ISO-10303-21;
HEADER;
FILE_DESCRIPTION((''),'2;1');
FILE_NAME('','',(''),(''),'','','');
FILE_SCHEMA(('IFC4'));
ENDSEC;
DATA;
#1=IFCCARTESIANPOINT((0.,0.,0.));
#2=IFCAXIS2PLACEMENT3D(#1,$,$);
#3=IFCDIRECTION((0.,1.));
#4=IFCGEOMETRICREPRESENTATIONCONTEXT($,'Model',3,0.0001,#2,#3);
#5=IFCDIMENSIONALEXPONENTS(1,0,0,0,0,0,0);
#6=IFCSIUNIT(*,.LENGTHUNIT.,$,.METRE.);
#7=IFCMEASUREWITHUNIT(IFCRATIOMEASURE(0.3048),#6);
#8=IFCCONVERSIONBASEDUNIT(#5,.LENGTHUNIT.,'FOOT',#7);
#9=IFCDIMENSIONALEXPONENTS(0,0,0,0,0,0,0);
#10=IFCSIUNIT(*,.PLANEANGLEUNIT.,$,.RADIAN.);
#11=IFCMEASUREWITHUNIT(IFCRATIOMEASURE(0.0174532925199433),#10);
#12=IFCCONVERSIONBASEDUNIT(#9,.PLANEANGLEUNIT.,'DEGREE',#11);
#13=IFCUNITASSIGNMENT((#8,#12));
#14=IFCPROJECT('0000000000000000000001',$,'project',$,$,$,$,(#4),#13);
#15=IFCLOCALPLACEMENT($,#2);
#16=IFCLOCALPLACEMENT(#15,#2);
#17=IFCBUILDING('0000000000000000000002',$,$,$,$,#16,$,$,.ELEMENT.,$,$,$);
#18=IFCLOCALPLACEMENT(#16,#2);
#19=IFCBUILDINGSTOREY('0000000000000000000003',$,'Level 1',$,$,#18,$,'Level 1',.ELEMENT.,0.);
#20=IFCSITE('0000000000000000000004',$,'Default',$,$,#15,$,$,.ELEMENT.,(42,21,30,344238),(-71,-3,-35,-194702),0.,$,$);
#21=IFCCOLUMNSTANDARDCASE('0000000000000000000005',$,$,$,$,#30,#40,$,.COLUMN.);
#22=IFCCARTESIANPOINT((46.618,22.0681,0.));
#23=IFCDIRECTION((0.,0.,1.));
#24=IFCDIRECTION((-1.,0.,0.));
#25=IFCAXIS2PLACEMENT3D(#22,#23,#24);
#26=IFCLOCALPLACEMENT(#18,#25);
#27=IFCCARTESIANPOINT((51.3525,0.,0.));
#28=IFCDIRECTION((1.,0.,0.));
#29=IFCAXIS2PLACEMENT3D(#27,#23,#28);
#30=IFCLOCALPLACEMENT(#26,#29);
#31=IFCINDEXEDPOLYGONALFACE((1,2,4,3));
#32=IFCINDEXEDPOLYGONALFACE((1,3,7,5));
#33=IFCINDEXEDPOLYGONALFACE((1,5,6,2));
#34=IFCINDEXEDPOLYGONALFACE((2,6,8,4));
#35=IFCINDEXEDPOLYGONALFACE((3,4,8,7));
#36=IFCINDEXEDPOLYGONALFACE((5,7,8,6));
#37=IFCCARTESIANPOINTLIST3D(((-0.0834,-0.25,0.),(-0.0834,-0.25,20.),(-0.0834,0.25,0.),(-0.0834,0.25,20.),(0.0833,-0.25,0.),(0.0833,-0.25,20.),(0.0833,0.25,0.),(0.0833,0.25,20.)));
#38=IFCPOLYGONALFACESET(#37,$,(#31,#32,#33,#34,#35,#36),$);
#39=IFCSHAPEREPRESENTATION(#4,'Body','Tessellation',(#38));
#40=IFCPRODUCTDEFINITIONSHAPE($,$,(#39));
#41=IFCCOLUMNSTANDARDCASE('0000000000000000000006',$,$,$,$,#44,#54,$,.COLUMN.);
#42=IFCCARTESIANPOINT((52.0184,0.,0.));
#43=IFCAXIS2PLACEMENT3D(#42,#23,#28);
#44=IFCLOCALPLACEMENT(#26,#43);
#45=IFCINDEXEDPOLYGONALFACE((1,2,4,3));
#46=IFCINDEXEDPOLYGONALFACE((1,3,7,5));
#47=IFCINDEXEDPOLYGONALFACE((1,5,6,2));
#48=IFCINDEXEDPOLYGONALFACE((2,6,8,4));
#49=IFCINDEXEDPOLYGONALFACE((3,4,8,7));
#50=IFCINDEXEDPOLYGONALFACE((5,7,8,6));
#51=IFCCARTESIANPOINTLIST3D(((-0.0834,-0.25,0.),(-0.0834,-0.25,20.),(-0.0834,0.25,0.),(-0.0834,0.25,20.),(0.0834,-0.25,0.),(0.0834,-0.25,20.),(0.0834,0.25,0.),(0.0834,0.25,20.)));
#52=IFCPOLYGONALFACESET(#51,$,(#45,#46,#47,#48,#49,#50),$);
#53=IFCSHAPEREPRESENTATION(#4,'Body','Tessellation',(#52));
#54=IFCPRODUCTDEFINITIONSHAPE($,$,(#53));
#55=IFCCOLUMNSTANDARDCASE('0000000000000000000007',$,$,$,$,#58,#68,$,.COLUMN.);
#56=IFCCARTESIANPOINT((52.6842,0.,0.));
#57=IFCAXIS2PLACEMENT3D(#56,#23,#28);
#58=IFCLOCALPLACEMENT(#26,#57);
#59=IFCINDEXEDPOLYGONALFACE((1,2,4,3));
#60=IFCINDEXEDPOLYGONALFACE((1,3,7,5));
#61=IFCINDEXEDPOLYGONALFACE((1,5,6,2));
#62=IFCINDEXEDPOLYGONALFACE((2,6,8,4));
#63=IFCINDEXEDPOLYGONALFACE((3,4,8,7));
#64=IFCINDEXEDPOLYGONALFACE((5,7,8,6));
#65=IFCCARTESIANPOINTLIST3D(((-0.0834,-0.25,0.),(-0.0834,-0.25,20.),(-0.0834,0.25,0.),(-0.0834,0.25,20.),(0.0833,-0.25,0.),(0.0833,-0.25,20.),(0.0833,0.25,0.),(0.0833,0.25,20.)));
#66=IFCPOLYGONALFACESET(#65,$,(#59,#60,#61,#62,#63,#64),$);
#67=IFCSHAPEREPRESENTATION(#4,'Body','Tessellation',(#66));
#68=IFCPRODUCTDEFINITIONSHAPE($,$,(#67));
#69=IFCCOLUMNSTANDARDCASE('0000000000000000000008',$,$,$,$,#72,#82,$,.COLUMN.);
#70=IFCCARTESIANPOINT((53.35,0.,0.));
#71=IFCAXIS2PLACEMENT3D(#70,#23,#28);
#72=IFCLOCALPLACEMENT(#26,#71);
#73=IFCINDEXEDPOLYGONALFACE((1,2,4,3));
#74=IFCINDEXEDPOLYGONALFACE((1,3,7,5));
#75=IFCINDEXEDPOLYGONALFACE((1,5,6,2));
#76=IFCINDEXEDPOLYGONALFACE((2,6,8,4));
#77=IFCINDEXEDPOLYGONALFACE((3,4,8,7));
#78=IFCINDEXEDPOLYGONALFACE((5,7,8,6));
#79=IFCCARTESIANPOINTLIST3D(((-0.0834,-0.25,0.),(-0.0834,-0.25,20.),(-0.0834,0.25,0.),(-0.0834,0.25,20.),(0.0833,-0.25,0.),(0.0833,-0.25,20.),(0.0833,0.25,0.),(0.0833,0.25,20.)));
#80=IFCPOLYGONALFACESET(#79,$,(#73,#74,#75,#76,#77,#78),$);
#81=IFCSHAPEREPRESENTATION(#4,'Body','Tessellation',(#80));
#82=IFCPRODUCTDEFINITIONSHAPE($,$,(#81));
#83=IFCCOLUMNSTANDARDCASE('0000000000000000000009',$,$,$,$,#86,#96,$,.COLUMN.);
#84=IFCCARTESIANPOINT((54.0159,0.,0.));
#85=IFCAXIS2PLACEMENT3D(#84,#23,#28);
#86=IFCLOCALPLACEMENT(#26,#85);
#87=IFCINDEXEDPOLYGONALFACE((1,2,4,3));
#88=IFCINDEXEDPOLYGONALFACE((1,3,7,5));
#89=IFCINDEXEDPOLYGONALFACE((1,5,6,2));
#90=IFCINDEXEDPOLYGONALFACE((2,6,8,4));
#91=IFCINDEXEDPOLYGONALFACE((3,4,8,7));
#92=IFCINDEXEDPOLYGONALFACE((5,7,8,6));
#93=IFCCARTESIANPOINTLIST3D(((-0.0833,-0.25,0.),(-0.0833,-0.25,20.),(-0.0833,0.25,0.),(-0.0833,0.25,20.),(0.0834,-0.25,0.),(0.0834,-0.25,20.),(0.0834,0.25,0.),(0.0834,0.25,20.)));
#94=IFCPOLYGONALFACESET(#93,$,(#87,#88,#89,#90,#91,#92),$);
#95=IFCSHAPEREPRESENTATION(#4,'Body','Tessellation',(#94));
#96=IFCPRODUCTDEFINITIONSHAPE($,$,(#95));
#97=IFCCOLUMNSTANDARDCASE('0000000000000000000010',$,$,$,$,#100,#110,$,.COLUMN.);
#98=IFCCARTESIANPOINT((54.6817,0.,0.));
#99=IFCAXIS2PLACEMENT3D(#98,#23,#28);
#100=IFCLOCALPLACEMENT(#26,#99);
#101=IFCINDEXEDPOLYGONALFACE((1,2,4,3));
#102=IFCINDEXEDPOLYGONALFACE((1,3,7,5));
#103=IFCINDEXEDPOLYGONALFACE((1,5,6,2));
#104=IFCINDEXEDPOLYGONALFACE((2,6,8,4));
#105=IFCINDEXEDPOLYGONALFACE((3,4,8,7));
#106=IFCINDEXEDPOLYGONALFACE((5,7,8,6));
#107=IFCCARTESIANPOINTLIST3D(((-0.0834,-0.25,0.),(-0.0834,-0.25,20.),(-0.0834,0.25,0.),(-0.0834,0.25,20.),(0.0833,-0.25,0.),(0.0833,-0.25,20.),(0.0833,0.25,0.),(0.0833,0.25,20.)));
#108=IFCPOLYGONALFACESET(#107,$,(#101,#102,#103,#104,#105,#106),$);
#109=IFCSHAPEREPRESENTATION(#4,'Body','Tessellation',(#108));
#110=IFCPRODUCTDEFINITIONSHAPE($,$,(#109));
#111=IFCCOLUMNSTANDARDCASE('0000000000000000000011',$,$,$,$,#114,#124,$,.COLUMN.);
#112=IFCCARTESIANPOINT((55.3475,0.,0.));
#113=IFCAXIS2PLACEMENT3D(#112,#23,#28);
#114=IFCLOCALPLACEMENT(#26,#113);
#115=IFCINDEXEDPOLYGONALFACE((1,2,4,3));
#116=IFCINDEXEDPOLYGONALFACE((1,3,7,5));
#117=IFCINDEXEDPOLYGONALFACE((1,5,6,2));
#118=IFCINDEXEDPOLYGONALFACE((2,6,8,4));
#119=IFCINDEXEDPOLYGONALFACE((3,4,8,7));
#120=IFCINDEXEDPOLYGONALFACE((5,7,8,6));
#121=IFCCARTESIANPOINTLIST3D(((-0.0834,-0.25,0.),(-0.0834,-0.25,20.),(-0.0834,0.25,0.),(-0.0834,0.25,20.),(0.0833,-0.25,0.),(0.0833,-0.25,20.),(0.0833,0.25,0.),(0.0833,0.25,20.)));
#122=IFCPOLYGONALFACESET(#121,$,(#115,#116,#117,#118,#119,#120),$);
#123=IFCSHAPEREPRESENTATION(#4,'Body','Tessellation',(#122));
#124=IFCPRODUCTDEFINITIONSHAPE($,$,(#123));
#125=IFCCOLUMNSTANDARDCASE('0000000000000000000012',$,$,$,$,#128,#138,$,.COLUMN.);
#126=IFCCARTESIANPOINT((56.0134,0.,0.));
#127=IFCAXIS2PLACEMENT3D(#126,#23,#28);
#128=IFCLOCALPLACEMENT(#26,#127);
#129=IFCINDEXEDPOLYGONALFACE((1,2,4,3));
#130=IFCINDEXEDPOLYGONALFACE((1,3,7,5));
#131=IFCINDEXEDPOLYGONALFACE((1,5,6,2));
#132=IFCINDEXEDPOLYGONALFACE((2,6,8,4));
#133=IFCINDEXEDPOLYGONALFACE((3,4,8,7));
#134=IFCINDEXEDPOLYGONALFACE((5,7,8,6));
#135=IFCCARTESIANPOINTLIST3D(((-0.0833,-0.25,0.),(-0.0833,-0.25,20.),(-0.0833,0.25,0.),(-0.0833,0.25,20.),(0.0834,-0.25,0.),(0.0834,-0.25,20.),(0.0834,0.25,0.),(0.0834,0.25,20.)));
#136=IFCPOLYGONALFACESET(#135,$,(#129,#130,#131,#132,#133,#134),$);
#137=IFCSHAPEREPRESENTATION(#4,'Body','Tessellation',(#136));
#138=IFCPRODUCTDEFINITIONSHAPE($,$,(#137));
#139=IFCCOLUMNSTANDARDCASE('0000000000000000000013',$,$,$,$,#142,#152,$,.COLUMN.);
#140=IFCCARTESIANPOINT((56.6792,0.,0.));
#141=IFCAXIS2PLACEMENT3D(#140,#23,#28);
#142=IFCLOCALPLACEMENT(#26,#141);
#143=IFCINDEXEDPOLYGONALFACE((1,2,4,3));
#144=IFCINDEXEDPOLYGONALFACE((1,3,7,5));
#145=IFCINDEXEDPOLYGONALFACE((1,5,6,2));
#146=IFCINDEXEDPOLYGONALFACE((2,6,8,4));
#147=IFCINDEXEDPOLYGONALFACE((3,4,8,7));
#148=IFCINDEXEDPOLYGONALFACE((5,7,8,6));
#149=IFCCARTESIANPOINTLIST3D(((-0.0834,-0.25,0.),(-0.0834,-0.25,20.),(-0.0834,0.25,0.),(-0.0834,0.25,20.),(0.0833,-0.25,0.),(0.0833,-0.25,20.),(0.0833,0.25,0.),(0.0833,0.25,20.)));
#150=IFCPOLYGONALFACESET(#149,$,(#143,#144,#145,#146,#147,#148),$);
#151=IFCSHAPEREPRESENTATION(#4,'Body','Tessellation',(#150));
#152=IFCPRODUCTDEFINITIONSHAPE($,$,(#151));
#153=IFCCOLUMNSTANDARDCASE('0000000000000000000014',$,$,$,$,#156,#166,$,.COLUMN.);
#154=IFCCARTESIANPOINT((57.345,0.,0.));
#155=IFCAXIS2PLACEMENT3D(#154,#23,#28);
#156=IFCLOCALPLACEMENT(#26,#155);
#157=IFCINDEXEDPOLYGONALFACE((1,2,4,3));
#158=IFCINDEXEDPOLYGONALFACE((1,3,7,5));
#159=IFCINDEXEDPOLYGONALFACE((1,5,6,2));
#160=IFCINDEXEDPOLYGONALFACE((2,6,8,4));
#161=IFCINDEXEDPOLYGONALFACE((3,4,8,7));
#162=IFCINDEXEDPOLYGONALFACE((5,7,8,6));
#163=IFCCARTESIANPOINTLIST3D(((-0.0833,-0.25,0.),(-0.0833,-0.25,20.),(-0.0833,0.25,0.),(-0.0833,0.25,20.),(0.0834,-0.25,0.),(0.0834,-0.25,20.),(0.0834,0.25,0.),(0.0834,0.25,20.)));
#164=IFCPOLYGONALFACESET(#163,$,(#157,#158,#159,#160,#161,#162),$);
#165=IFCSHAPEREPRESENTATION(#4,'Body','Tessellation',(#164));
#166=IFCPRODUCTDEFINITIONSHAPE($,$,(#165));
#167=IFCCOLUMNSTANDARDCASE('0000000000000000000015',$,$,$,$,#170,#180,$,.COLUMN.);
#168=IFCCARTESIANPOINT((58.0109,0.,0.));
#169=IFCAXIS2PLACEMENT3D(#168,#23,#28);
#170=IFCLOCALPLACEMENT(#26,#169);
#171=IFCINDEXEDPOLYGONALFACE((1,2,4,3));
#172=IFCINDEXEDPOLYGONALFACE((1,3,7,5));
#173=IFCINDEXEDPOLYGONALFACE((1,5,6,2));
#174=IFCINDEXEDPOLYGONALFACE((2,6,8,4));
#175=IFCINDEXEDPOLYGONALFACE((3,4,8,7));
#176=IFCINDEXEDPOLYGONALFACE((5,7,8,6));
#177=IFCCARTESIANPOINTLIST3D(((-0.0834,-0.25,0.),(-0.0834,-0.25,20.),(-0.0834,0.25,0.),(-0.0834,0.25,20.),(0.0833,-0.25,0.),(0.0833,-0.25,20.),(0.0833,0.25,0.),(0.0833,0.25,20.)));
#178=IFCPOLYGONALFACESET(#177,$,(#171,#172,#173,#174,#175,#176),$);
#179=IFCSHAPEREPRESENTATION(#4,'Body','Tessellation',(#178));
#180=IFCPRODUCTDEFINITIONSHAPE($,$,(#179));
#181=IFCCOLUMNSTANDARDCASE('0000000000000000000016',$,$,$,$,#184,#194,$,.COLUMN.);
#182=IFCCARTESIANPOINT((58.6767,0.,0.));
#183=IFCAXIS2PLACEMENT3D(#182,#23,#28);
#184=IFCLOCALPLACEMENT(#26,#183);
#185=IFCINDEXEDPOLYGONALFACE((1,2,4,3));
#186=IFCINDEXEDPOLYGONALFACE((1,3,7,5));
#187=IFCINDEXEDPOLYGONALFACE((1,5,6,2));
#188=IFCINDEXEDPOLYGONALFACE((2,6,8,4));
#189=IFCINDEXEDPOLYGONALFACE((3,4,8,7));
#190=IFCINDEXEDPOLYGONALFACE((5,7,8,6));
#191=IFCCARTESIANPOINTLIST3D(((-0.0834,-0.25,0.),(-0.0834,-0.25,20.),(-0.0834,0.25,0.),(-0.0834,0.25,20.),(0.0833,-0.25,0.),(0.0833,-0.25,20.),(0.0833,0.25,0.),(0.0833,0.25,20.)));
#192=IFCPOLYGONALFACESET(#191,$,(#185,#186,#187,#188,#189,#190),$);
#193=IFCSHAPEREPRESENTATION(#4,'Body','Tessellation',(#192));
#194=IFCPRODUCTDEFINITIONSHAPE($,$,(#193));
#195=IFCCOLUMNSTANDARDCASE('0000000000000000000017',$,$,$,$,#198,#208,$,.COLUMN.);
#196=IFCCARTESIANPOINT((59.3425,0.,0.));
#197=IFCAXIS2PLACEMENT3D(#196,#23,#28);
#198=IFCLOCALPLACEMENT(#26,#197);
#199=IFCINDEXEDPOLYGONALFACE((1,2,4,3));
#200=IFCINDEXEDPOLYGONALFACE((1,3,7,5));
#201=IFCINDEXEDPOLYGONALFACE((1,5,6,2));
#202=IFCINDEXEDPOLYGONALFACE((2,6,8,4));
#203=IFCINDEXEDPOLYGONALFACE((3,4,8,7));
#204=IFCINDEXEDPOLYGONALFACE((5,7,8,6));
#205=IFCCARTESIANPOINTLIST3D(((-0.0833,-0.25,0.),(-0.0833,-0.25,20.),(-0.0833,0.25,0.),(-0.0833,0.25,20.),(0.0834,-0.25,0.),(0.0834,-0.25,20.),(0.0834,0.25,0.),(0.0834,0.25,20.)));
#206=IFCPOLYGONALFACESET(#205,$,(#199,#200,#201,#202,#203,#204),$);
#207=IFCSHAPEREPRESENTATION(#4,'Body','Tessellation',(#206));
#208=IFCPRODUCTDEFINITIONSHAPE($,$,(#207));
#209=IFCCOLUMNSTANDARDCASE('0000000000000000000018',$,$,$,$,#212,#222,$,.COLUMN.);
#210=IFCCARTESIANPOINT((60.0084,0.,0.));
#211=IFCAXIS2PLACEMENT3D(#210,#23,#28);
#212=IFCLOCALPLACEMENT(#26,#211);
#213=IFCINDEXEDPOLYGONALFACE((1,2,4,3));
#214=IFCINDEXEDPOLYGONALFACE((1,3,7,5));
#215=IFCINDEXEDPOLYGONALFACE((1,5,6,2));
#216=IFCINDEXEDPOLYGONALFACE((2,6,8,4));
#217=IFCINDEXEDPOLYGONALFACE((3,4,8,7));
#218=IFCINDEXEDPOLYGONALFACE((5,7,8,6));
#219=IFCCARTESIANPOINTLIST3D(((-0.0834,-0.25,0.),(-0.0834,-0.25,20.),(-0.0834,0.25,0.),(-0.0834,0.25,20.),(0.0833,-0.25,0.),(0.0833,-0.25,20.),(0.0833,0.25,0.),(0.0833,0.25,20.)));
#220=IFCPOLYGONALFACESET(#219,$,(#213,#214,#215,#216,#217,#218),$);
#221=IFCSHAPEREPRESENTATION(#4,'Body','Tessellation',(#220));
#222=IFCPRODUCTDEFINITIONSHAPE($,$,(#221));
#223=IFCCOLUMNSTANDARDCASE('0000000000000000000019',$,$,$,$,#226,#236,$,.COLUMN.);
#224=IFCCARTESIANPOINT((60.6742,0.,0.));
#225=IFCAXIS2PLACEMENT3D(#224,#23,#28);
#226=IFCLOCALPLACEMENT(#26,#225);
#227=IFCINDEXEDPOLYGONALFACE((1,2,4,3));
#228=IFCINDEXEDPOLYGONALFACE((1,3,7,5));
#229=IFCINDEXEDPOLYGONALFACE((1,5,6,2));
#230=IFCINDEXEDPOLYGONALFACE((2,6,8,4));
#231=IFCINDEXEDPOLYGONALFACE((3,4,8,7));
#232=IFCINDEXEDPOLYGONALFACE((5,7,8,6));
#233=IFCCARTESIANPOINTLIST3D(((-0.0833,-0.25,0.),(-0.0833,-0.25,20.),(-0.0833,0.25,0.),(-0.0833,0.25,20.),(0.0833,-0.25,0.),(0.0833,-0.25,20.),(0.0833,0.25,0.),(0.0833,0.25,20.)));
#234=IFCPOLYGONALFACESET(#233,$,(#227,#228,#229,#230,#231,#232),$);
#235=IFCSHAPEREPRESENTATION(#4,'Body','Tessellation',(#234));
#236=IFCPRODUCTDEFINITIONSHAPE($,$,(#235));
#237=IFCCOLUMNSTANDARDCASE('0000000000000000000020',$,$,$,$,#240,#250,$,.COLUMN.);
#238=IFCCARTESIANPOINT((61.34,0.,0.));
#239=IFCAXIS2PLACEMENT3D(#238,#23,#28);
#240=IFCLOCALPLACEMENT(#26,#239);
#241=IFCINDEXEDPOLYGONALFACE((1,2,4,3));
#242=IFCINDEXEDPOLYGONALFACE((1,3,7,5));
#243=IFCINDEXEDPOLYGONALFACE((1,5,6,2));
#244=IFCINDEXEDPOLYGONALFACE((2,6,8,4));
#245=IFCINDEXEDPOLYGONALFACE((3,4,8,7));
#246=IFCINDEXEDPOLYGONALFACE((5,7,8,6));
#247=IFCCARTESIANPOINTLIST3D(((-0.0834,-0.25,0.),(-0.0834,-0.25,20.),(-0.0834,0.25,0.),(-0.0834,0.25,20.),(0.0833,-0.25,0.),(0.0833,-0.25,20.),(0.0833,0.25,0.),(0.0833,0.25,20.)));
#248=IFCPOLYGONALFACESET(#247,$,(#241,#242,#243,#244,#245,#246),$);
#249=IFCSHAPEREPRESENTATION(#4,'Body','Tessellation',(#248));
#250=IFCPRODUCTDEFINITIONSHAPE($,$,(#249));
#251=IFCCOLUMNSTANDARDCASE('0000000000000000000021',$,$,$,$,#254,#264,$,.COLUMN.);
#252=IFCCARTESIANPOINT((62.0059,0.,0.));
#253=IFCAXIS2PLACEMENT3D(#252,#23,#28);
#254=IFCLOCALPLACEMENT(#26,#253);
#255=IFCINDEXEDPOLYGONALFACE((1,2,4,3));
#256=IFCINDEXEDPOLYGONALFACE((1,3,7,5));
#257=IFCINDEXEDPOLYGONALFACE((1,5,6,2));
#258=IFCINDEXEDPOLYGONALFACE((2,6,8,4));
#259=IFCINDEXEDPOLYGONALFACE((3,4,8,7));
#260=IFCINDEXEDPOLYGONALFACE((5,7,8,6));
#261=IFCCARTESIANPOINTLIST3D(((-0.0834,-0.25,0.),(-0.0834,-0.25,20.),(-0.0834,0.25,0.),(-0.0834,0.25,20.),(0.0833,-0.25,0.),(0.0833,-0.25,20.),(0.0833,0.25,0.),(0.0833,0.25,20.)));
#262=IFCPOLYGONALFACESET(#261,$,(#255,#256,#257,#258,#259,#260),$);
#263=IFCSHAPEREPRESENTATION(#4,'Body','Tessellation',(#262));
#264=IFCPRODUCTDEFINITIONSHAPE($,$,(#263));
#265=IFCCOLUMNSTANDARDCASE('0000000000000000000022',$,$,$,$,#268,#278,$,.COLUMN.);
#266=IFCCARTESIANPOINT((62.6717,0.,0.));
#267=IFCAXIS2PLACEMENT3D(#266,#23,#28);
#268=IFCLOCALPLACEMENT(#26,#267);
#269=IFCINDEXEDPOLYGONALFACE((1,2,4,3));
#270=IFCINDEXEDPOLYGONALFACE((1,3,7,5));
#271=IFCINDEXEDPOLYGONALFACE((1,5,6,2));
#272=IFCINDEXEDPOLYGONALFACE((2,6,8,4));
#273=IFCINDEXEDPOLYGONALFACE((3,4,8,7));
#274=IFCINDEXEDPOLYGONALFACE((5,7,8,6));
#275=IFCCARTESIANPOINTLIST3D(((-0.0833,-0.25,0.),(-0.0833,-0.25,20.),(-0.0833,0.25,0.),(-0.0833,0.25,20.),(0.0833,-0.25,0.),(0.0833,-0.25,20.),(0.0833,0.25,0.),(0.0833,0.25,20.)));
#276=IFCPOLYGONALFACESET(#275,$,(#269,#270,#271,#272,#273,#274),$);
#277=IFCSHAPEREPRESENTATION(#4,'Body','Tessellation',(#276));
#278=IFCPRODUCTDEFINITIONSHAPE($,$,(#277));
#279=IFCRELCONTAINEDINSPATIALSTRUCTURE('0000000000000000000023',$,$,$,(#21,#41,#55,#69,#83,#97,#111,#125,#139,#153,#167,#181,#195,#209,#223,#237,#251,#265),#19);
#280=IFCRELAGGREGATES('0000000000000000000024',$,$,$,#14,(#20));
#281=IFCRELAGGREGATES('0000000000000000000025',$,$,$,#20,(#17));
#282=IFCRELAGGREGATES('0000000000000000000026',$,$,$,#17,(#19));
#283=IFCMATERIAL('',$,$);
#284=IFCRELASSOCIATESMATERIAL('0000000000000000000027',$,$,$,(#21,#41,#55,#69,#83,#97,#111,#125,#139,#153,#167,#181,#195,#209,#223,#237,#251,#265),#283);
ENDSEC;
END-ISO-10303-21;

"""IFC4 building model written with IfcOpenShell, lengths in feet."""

from ifc_helpers import new_model, entity, si_unit, converted_unit, direction, frame, origin, place, context, project, spatial, rectangle, extrude, material, element, save


model = new_model("IFC4")

# Units and contexts
model_context = context("Model", 3, precision=0.0001, world=origin(), true_north=direction((0.0, 1.0)))
ifc_project = project(units=[converted_unit("LENGTHUNIT", "FOOT", entity("IfcRatioMeasure", 0.3048), si_unit("LENGTHUNIT", "METRE"), dimensions=[1, 0, 0, 0, 0, 0, 0]), converted_unit("PLANEANGLEUNIT", "DEGREE", entity("IfcRatioMeasure", 0.0174532925199433), si_unit("PLANEANGLEUNIT", "RADIAN"), dimensions=[0, 0, 0, 0, 0, 0, 0])], contexts=[model_context])

# Site, building, storey
site_placement = place(None, origin())
site = spatial("IfcSite", under=ifc_project, at=site_placement, Name="Default", CompositionType="ELEMENT", RefLatitude=(42, 21, 30, 344238), RefLongitude=(-71, -3, -35, -194702), RefElevation=0.0)
building_placement = place(site_placement, origin())
building = spatial("IfcBuilding", under=site, at=building_placement, CompositionType="ELEMENT")
storey_placement = place(building_placement, origin())
storey = spatial("IfcBuildingStorey", under=building, at=storey_placement, Name="Level 1", LongName="Level 1", CompositionType="ELEMENT", Elevation=0.0)

# Columns
ifc_material_1 = material(Name="")
placement = place(storey_placement, frame((46.618, 22.0681, 0.0), z_axis=(0.0, 0.0, 1.0), x_axis=(-1.0, 0.0, 0.0)))
for number, where, z_axis, x_axis in (
    (1, (51.3525, 0.0, 0.0), (0.0, 0.0, 1.0), (1.0, 0.0, 0.0)),
    (2, (52.0184, 0.0, 0.0), (0.0, 0.0, 1.0), (1.0, 0.0, 0.0)),
    (3, (52.6842, 0.0, 0.0), (0.0, 0.0, 1.0), (1.0, 0.0, 0.0)),
    (4, (53.35, 0.0, 0.0), (0.0, 0.0, 1.0), (1.0, 0.0, 0.0)),
    (5, (54.0159, 0.0, 0.0), (0.0, 0.0, 1.0), (1.0, 0.0, 0.0)),
    (6, (54.6817, 0.0, 0.0), (0.0, 0.0, 1.0), (1.0, 0.0, 0.0)),
    (7, (55.3475, 0.0, 0.0), (0.0, 0.0, 1.0), (1.0, 0.0, 0.0)),
    (8, (56.0134, 0.0, 0.0), (0.0, 0.0, 1.0), (1.0, 0.0, 0.0)),
    (9, (56.6792, 0.0, 0.0), (0.0, 0.0, 1.0), (1.0, 0.0, 0.0)),
    (10, (57.345, 0.0, 0.0), (0.0, 0.0, 1.0), (1.0, 0.0, 0.0)),
    (11, (58.0109, 0.0, 0.0), (0.0, 0.0, 1.0), (1.0, 0.0, 0.0)),
    (12, (58.6767, 0.0, 0.0), (0.0, 0.0, 1.0), (1.0, 0.0, 0.0)),
    (13, (59.3425, 0.0, 0.0), (0.0, 0.0, 1.0), (1.0, 0.0, 0.0)),
    (14, (60.0084, 0.0, 0.0), (0.0, 0.0, 1.0), (1.0, 0.0, 0.0)),
    (15, (60.6742, 0.0, 0.0), (0.0, 0.0, 1.0), (1.0, 0.0, 0.0)),
    (16, (61.34, 0.0, 0.0), (0.0, 0.0, 1.0), (1.0, 0.0, 0.0)),
    (17, (62.0059, 0.0, 0.0), (0.0, 0.0, 1.0), (1.0, 0.0, 0.0)),
    (18, (62.6717, 0.0, 0.0), (0.0, 0.0, 1.0), (1.0, 0.0, 0.0)),
):
    element("IfcColumnStandardCase", number, at=place(placement, frame(where, z_axis=z_axis, x_axis=x_axis)), inside=storey, material=ifc_material_1, PredefinedType="COLUMN", context=model_context, shape_type="SweptSolid", body=[
        extrude(rectangle(XDim=0.1667, YDim=0.5), origin(), (0.0, 0.0, 1.0), 20.0),
    ])

save(model, "model.ifc")
